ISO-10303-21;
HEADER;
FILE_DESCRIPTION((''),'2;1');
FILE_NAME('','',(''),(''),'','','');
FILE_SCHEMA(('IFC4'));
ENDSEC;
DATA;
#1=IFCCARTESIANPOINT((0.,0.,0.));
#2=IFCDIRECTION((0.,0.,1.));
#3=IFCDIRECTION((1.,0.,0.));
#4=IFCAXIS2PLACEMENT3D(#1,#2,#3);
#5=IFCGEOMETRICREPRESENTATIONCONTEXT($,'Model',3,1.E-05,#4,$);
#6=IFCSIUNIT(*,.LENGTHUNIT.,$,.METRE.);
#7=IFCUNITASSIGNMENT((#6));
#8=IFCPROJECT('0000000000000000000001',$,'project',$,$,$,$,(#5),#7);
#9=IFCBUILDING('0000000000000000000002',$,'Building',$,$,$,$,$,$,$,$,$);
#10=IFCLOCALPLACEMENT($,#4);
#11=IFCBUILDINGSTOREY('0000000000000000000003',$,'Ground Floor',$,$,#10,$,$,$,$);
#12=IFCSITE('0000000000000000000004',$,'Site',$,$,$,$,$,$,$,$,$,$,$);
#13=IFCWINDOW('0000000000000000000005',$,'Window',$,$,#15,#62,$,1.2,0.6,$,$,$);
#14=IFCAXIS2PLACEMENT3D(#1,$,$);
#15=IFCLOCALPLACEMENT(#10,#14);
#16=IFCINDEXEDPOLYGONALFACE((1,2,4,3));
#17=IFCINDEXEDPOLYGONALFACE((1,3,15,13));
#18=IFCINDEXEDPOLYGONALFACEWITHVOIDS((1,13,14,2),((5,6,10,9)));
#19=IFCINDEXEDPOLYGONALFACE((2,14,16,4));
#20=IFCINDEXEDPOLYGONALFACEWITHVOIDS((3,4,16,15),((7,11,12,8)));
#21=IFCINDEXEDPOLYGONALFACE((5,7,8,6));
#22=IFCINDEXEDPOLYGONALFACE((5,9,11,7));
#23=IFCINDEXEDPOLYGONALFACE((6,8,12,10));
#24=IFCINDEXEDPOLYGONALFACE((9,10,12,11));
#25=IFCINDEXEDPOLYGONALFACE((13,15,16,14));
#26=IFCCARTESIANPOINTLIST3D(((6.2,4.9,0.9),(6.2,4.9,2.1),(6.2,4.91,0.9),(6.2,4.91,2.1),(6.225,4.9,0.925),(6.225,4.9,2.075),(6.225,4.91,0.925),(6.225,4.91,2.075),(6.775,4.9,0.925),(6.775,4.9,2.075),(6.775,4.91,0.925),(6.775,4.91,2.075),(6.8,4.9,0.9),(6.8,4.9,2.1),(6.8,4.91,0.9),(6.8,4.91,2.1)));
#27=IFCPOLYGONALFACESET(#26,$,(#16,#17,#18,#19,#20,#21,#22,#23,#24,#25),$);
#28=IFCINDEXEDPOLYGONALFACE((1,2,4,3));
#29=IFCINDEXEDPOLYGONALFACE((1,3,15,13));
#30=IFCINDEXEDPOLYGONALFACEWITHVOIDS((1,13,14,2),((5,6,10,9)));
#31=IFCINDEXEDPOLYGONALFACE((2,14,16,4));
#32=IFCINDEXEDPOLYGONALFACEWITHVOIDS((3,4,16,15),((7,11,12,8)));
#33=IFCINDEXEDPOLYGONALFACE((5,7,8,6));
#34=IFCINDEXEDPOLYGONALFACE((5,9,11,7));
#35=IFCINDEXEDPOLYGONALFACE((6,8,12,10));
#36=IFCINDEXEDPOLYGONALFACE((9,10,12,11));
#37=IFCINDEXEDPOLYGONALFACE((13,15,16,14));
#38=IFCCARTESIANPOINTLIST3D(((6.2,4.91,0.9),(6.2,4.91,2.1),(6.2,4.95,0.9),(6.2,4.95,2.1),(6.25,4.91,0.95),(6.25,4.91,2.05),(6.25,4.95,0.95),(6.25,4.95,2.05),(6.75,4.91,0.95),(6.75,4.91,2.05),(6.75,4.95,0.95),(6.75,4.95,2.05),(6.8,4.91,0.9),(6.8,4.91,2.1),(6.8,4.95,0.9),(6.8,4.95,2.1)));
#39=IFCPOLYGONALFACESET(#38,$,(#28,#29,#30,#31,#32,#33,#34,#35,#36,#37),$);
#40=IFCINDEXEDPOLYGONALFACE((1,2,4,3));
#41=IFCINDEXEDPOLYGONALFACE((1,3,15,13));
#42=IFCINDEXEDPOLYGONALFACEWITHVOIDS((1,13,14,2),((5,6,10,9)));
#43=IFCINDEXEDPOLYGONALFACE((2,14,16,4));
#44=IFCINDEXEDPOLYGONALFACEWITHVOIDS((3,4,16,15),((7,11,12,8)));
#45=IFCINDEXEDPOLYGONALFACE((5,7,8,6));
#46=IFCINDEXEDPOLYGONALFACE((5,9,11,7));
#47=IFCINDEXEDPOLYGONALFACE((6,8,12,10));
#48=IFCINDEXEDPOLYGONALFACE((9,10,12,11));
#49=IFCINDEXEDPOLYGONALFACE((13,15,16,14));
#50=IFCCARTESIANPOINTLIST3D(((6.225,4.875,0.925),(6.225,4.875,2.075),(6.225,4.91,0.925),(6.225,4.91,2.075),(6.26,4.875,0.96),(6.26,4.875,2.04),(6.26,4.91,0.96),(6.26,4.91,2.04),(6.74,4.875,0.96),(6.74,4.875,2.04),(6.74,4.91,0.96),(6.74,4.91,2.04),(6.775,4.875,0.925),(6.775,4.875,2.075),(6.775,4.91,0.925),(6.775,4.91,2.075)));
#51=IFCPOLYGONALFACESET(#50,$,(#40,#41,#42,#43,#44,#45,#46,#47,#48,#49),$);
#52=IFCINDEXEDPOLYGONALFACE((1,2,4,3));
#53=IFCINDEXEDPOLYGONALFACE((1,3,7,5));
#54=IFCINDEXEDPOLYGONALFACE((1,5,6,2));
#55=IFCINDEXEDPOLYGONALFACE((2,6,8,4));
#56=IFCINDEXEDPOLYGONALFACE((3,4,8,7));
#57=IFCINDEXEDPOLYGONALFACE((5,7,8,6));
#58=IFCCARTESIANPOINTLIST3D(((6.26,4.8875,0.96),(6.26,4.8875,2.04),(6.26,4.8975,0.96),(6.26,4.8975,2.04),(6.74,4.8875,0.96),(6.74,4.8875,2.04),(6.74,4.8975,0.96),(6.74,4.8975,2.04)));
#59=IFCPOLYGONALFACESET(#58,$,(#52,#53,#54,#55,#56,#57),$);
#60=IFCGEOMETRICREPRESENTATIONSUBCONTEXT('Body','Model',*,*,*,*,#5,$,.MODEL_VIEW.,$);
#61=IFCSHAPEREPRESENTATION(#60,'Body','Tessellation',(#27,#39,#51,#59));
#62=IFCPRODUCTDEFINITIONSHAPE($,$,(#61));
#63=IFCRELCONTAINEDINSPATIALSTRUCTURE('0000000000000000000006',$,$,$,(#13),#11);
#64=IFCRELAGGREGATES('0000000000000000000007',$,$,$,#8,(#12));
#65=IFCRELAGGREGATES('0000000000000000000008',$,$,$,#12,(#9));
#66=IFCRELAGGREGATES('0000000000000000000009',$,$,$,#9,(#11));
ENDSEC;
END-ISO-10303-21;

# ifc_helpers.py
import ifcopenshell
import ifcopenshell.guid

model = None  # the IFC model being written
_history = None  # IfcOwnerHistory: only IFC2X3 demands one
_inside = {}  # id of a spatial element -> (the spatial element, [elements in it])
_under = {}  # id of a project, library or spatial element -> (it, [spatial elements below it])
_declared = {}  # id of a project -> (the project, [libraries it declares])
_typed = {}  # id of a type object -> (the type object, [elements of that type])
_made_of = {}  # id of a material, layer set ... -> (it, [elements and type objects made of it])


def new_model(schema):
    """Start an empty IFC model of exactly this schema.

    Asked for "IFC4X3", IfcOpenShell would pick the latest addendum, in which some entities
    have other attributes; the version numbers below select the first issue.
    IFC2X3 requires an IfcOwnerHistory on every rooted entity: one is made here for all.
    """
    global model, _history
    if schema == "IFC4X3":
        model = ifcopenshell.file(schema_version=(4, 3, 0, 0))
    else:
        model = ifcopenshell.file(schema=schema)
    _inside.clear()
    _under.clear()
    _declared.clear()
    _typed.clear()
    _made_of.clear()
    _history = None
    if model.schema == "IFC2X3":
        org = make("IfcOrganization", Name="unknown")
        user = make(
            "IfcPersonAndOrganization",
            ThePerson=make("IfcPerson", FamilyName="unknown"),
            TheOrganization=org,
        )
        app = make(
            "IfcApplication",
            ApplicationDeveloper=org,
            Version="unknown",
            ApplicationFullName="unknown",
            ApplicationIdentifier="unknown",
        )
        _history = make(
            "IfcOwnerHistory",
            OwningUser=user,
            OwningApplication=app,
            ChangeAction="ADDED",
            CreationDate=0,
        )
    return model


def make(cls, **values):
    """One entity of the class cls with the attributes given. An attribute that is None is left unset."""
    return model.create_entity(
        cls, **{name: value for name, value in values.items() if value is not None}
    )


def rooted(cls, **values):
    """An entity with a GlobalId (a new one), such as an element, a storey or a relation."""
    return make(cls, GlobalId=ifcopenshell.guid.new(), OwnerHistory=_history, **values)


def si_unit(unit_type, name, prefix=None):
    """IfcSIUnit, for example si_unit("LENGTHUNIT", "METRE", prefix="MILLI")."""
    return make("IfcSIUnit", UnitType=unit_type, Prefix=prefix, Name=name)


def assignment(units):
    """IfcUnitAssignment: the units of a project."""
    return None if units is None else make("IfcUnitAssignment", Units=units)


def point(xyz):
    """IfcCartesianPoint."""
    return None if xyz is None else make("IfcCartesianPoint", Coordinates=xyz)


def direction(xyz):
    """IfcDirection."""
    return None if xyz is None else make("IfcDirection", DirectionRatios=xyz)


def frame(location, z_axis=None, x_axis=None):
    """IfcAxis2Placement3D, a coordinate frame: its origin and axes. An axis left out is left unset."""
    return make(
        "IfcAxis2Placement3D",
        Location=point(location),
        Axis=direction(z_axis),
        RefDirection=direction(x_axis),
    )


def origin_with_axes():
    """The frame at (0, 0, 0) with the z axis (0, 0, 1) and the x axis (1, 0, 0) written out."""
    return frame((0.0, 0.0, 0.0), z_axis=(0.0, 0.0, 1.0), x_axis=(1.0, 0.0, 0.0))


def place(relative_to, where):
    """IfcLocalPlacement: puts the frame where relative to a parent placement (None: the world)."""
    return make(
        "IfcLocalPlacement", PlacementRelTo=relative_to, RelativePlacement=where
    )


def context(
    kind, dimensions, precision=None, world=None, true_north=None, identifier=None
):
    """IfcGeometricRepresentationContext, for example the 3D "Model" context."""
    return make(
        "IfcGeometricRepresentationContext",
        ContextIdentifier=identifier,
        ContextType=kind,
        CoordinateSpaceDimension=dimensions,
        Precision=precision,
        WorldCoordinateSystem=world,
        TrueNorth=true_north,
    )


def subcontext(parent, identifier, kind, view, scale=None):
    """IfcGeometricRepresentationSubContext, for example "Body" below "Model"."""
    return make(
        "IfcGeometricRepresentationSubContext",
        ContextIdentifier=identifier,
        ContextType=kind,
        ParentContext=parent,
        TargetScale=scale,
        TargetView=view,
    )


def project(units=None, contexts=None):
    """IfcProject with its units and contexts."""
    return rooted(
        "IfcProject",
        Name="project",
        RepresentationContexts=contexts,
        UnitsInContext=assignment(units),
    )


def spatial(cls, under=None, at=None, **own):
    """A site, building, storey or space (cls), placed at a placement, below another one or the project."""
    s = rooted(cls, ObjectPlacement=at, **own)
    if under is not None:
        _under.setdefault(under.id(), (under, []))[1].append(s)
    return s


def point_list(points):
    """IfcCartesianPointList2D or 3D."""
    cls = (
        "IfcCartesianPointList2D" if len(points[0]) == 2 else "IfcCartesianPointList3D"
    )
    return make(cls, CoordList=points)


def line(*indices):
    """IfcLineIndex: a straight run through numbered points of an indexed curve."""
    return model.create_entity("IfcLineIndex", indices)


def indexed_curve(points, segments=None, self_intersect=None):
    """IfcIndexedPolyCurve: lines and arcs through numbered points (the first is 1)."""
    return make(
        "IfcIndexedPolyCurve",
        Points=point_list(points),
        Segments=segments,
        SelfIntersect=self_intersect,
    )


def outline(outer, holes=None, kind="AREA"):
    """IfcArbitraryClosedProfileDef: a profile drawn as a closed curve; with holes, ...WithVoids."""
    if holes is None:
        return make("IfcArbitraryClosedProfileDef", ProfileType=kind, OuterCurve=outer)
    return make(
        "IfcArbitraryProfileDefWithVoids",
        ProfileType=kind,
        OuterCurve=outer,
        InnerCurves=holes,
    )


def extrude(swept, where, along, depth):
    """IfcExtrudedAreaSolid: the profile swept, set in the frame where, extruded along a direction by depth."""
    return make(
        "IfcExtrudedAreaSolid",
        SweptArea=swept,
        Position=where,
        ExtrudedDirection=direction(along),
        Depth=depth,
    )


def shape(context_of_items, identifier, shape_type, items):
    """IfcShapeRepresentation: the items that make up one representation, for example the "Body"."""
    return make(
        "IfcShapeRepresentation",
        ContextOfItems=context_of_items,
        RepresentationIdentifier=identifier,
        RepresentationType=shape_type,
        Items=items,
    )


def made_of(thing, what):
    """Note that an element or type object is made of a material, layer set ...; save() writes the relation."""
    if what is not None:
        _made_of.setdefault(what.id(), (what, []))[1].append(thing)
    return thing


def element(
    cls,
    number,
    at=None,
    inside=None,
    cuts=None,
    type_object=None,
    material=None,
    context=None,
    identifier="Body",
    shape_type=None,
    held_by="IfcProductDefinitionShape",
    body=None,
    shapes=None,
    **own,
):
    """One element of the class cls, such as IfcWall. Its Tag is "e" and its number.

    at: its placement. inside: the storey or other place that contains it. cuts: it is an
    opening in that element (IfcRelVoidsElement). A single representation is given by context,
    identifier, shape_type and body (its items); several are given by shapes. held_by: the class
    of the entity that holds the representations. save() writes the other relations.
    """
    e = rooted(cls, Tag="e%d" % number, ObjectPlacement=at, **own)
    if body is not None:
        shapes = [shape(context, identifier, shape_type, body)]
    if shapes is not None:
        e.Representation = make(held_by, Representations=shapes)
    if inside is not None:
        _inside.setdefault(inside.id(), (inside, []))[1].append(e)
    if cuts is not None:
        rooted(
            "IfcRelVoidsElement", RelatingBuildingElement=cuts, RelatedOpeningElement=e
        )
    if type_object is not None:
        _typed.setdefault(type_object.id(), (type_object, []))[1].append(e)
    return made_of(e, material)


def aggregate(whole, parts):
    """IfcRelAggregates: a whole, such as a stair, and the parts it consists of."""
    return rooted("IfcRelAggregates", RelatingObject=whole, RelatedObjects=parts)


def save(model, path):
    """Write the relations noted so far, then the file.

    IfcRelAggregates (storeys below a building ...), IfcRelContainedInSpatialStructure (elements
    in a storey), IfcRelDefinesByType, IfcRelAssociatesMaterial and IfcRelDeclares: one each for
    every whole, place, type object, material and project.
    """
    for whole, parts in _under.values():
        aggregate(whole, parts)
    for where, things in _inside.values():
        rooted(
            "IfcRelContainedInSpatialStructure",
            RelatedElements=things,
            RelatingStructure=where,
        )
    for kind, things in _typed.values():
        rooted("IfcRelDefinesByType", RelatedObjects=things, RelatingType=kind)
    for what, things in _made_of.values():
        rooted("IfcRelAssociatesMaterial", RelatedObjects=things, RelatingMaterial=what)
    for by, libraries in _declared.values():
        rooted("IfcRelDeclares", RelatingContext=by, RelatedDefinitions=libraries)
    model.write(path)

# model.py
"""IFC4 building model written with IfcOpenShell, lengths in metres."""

from ifc_helpers import new_model, si_unit, frame, origin_with_axes, place, context, subcontext, project, spatial, line, indexed_curve, outline, extrude, element, save


model = new_model("IFC4")

# Units and contexts
model_context = context("Model", 3, precision=1e-05, world=origin_with_axes())
body_context = subcontext(model_context, "Body", "Model", "MODEL_VIEW")
ifc_project = project(units=[si_unit("LENGTHUNIT", "METRE")], contexts=[model_context])

# Site, building, storey
site = spatial("IfcSite", under=ifc_project, Name="Site")
building = spatial("IfcBuilding", under=site, Name="Building")
storey_placement = place(None, origin_with_axes())
storey = spatial("IfcBuildingStorey", under=building, at=storey_placement, Name="Ground Floor")

# Window
window_1_placement = place(storey_placement, frame((6.8, 5.0, 0.9), z_axis=(0.0, 0.0, 1.0), x_axis=(-1.0, 0.0, 0.0)))
element("IfcWindow", 1, at=window_1_placement, inside=storey, Name="Window", OverallHeight=1.2, OverallWidth=0.6, context=body_context, shape_type="SweptSolid", body=[
    extrude(outline(indexed_curve([(0.0, 0.0), (0.6, 0.0), (0.6, 1.2), (0.0, 1.2)], segments=[line(1, 2, 3, 4, 1)]), holes=[indexed_curve([(0.025, 0.025), (0.575, 0.025), (0.575, 1.175), (0.025, 1.175)], segments=[line(1, 2, 3, 4, 1)])]), frame((0.0, 0.09, 0.0), z_axis=(0.0, -1.0, 0.0), x_axis=(1.0, 0.0, 0.0)), (0.0, 0.0, -1.0), 0.01),
    extrude(outline(indexed_curve([(0.0, 0.0), (0.6, 0.0), (0.6, 1.2), (0.0, 1.2)], segments=[line(1, 2, 3, 4, 1)]), holes=[indexed_curve([(0.05, 0.05), (0.55, 0.05), (0.55, 1.15), (0.05, 1.15)], segments=[line(1, 2, 3, 4, 1)])]), frame((0.0, 0.05, 0.0), z_axis=(0.0, -1.0, 0.0), x_axis=(1.0, 0.0, 0.0)), (0.0, 0.0, -1.0), 0.04),
    extrude(outline(indexed_curve([(0.0, 0.0), (0.55, 0.0), (0.55, 1.15), (0.0, 1.15)], segments=[line(1, 2, 3, 4, 1)]), holes=[indexed_curve([(0.035, 0.035), (0.515, 0.035), (0.515, 1.115), (0.035, 1.115)], segments=[line(1, 2, 3, 4, 1)])]), frame((0.025, 0.09, 0.025), z_axis=(0.0, -1.0, 0.0), x_axis=(1.0, 0.0, 0.0)), (0.0, 0.0, -1.0), 0.035),
    extrude(outline(indexed_curve([(0.035, 0.035), (0.515, 0.035), (0.515, 1.115), (0.035, 1.115)], segments=[line(1, 2, 3, 4, 1)])), frame((0.025, 0.1025, 0.025), z_axis=(0.0, -1.0, 0.0), x_axis=(1.0, 0.0, 0.0)), (0.0, 0.0, -1.0), 0.01),
])

save(model, "model.ifc")
